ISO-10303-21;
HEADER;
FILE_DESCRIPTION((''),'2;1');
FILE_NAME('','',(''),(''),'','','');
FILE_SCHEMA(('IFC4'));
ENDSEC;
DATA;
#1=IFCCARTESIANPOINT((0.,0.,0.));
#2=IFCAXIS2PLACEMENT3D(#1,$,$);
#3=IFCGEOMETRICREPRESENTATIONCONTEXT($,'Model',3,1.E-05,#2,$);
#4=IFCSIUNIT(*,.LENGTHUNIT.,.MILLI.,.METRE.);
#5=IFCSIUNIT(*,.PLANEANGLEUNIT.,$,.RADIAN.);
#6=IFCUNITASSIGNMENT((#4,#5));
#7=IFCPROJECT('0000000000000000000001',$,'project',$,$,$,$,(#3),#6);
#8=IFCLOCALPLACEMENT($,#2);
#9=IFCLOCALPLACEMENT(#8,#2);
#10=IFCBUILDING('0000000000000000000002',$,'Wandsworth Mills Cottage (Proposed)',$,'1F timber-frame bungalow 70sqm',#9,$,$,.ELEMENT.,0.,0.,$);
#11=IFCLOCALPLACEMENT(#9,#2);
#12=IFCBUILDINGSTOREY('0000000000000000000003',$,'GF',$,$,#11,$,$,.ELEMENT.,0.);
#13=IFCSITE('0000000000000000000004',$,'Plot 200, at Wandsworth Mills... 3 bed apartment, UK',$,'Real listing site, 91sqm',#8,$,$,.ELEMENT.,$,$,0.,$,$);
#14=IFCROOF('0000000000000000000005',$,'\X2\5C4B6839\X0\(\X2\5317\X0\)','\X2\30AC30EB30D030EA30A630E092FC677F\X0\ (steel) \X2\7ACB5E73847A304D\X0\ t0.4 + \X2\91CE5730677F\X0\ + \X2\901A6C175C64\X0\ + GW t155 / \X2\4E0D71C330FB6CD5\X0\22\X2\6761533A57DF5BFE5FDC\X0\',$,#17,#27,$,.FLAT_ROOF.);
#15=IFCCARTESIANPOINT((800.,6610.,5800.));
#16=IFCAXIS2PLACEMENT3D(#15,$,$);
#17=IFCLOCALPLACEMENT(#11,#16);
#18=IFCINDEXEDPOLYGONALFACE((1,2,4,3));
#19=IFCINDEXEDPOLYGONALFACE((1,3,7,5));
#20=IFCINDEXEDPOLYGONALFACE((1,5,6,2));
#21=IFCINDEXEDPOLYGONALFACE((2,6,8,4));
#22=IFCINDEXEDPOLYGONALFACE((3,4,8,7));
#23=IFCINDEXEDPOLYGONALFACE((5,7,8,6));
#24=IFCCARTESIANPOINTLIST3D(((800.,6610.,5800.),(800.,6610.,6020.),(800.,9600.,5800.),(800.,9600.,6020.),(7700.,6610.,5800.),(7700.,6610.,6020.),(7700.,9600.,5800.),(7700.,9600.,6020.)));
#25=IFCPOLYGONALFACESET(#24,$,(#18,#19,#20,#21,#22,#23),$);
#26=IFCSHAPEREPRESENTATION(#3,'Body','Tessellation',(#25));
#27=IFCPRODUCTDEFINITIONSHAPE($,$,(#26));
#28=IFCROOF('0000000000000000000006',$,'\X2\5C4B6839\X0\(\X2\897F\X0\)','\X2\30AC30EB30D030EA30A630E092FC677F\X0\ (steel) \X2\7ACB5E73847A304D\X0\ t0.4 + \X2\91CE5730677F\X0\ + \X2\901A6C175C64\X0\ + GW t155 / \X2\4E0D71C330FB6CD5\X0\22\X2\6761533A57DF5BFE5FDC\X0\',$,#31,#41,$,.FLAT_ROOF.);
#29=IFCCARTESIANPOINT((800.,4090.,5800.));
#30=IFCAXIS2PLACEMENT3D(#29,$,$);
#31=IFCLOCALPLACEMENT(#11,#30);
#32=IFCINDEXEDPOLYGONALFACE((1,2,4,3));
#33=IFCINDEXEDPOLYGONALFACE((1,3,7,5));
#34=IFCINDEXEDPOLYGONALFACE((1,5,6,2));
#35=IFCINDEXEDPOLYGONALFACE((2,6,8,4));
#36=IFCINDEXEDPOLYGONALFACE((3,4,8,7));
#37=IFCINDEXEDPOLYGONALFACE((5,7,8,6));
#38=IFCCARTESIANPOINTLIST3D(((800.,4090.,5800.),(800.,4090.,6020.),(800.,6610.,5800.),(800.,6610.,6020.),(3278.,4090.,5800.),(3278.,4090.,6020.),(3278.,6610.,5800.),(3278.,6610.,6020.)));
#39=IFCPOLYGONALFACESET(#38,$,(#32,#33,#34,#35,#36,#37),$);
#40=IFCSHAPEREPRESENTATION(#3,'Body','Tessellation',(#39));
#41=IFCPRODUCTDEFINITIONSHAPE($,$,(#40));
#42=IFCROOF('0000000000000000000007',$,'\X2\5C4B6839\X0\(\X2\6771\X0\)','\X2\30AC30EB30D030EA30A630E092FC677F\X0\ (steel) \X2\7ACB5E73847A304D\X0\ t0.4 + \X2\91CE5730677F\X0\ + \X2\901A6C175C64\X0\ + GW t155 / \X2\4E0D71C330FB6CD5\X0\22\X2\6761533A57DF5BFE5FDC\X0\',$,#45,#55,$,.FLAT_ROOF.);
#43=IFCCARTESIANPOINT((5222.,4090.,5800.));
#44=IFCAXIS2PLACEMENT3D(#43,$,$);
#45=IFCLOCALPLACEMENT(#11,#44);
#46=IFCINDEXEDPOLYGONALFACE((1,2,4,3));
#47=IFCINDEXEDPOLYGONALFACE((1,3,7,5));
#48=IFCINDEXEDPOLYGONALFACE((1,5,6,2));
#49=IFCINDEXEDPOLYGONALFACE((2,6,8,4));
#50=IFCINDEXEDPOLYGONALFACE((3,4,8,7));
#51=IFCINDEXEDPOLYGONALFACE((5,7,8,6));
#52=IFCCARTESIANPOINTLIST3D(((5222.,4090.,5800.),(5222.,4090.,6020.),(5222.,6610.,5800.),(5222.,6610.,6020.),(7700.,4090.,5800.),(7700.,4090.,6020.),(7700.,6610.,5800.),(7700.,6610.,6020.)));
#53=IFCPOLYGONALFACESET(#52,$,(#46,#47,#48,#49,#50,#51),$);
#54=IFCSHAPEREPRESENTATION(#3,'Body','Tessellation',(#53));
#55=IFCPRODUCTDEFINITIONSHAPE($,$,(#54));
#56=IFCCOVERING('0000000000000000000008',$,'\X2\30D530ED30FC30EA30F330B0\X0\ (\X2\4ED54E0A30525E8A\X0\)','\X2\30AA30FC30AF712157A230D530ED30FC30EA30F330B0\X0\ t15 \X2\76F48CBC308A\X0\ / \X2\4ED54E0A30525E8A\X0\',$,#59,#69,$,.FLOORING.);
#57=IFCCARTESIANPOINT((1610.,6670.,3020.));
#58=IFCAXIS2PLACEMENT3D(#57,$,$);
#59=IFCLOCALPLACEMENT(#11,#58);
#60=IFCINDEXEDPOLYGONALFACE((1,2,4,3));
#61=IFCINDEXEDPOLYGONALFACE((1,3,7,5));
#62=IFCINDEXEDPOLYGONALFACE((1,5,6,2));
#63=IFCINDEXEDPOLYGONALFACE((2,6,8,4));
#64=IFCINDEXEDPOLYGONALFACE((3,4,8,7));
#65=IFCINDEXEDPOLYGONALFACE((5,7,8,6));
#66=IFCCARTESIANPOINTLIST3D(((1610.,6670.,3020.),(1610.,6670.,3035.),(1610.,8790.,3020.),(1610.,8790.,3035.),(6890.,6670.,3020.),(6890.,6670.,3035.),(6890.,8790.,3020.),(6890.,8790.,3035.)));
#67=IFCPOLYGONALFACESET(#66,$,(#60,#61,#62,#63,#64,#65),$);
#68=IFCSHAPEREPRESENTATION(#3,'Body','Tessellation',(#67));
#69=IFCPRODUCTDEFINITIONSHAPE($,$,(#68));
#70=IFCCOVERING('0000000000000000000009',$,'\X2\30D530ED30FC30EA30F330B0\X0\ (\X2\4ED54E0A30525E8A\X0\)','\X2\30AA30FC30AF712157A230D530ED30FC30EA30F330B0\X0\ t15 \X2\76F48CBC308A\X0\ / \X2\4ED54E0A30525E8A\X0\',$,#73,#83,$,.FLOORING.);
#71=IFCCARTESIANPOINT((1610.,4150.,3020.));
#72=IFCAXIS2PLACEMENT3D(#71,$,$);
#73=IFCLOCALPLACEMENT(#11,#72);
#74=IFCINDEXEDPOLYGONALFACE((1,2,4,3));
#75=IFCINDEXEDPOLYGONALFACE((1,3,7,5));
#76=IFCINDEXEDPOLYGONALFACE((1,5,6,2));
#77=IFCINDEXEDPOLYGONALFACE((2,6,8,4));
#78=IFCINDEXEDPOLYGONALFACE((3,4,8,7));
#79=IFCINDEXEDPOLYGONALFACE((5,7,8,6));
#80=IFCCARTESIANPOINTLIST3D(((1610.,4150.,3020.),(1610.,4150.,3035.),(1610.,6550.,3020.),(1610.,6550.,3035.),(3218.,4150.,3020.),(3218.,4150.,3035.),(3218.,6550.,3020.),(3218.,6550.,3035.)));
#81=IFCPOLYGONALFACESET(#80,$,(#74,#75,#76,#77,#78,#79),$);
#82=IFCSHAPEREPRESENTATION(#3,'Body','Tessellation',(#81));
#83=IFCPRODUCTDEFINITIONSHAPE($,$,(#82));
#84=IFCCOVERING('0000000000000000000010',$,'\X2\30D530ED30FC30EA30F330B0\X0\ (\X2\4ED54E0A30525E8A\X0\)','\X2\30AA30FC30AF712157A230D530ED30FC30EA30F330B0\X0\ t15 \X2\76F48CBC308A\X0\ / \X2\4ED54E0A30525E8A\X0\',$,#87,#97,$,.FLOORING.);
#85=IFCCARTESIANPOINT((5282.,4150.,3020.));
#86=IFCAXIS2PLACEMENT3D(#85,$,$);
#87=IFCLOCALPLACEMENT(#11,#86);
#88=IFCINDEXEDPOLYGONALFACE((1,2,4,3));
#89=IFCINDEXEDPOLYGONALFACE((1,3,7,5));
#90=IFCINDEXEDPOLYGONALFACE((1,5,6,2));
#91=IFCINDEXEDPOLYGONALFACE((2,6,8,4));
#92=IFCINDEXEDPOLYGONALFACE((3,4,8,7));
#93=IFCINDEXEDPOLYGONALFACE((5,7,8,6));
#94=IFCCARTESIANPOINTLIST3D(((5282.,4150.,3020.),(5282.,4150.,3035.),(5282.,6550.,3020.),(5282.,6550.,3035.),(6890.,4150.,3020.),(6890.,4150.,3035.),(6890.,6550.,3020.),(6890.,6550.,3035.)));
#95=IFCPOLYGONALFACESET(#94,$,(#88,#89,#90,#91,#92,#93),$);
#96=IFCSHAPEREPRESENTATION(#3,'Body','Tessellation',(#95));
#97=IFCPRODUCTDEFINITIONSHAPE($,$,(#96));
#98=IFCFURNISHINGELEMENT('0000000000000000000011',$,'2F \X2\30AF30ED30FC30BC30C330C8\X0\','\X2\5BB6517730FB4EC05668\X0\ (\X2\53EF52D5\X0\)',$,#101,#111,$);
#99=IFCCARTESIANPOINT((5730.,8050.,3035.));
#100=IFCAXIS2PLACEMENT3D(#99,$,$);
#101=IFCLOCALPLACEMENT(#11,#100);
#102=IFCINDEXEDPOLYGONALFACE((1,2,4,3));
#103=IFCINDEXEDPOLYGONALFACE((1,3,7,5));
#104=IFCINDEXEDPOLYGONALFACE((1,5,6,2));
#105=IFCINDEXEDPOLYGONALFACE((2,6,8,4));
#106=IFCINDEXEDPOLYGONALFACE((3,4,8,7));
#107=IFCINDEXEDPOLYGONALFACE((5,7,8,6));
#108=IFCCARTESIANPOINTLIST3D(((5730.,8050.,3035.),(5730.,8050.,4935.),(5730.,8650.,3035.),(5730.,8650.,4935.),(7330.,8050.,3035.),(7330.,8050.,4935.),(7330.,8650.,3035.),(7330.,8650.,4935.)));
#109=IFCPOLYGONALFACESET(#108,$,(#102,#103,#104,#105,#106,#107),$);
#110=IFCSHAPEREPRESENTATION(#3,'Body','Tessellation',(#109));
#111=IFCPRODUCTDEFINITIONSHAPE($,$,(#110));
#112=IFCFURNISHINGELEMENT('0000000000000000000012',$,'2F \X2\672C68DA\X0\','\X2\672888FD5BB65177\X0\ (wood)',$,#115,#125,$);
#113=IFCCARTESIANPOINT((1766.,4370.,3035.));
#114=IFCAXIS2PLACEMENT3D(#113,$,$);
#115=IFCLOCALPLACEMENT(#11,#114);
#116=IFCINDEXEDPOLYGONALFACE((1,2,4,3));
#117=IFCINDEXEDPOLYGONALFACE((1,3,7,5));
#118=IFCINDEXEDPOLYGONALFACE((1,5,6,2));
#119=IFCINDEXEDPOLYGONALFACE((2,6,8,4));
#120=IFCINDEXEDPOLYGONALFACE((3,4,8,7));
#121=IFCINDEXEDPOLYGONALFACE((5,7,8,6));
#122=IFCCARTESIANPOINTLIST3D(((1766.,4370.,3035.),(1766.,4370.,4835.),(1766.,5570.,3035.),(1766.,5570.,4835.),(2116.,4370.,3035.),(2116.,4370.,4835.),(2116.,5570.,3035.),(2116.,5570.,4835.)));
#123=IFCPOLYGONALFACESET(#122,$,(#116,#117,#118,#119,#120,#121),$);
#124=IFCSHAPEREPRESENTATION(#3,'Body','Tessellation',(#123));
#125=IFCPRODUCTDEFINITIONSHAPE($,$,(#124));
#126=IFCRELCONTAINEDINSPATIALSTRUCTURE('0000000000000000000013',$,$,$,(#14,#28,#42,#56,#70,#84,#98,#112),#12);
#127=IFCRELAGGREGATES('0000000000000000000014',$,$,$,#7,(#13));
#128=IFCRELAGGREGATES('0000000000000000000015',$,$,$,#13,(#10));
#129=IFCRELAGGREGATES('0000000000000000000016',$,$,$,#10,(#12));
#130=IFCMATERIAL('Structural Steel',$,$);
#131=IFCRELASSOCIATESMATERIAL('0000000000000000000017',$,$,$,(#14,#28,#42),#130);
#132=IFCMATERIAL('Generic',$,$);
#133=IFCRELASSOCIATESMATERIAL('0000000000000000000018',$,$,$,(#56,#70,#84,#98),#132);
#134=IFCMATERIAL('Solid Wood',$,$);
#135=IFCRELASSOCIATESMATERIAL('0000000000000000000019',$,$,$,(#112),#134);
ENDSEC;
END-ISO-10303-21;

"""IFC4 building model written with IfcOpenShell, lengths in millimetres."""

from ifc_helpers import new_model, si_unit, frame, frame_2d, origin, place, context, project, spatial, rectangle, extrude, material, element, save


model = new_model("IFC4")

# Units and contexts
model_context = context("Model", 3, precision=1e-05, world=origin())
ifc_project = project(units=[si_unit("LENGTHUNIT", "METRE", prefix="MILLI"), si_unit("PLANEANGLEUNIT", "RADIAN")], contexts=[model_context])

# Site, building, storey
site_placement = place(None, origin())
site = spatial("IfcSite", under=ifc_project, at=site_placement, Name="Plot 200, at Wandsworth Mills... 3 bed apartment, UK", ObjectType="Real listing site, 91sqm", CompositionType="ELEMENT", RefElevation=0.0)
building_placement = place(site_placement, origin())
building = spatial("IfcBuilding", under=site, at=building_placement, Name="Wandsworth Mills Cottage (Proposed)", ObjectType="1F timber-frame bungalow 70sqm", CompositionType="ELEMENT", ElevationOfRefHeight=0.0, ElevationOfTerrain=0.0)
storey_placement = place(building_placement, origin())
storey = spatial("IfcBuildingStorey", under=building, at=storey_placement, Name="GF", CompositionType="ELEMENT", Elevation=0.0)

# Shared definitions
ifc_material_1 = material(Name="Solid Wood")

# Roofs
ifc_material_2 = material(Name="Structural Steel")
for number, where, name in (
    (1, (800.0, 6610.0, 5800.0), "屋根(北)"),
):
    element("IfcRoof", number, at=place(storey_placement, frame(where)), inside=storey, material=ifc_material_2, Name=name, Description="ガルバリウム鋼板 (steel) 立平葺き t0.4 + 野地板 + 通気層 + GW t155 / 不燃・法22条区域対応", PredefinedType="FLAT_ROOF", context=model_context, shape_type="SweptSolid", body=[
        extrude(rectangle(XDim=6900.0, YDim=2990.0, at=frame_2d((3450.0, 1495.0))), frame((800.0, 6610.0, 5800.0)), (0.0, 0.0, 1.0), 220.0),
    ])
roof_1_placement = place(storey_placement, frame((800.0, 4090.0, 5800.0)))
element("IfcRoof", 2, at=roof_1_placement, inside=storey, material=ifc_material_2, Name="屋根(西)", Description="ガルバリウム鋼板 (steel) 立平葺き t0.4 + 野地板 + 通気層 + GW t155 / 不燃・法22条区域対応", PredefinedType="FLAT_ROOF", context=model_context, shape_type="SweptSolid", body=[
    extrude(rectangle(XDim=2478.0, YDim=2520.0, at=frame_2d((1239.0, 1260.0))), frame((800.0, 4090.0, 5800.0)), (0.0, 0.0, 1.0), 220.0),
])
roof_2_placement = place(storey_placement, frame((5222.0, 4090.0, 5800.0)))
element("IfcRoof", 3, at=roof_2_placement, inside=storey, material=ifc_material_2, Name="屋根(東)", Description="ガルバリウム鋼板 (steel) 立平葺き t0.4 + 野地板 + 通気層 + GW t155 / 不燃・法22条区域対応", PredefinedType="FLAT_ROOF", context=model_context, shape_type="SweptSolid", body=[
    extrude(rectangle(XDim=2478.0, YDim=2520.0, at=frame_2d((1239.0, 1260.0))), frame((5222.0, 4090.0, 5800.0)), (0.0, 0.0, 1.0), 220.0),
])

# Coverings
ifc_material_3 = material(Name="Generic")
covering_1_placement = place(storey_placement, frame((1610.0, 6670.0, 3020.0)))
element("IfcCovering", 4, at=covering_1_placement, inside=storey, material=ifc_material_3, Name="フローリング (仕上げ床)", Description="オーク無垢フローリング t15 直貼り / 仕上げ床", PredefinedType="FLOORING", context=model_context, shape_type="SweptSolid", body=[
    extrude(rectangle(XDim=5280.0, YDim=2120.0, at=frame_2d((2640.0, 1060.0))), frame((1610.0, 6670.0, 3020.0)), (0.0, 0.0, 1.0), 15.0),
])
covering_2_placement = place(storey_placement, frame((1610.0, 4150.0, 3020.0)))
element("IfcCovering", 5, at=covering_2_placement, inside=storey, material=ifc_material_3, Name="フローリング (仕上げ床)", Description="オーク無垢フローリング t15 直貼り / 仕上げ床", PredefinedType="FLOORING", context=model_context, shape_type="SweptSolid", body=[
    extrude(rectangle(XDim=1608.0, YDim=2400.0, at=frame_2d((804.0, 1200.0))), frame((1610.0, 4150.0, 3020.0)), (0.0, 0.0, 1.0), 15.0),
])
covering_3_placement = place(storey_placement, frame((5282.0, 4150.0, 3020.0)))
element("IfcCovering", 6, at=covering_3_placement, inside=storey, material=ifc_material_3, Name="フローリング (仕上げ床)", Description="オーク無垢フローリング t15 直貼り / 仕上げ床", PredefinedType="FLOORING", context=model_context, shape_type="SweptSolid", body=[
    extrude(rectangle(XDim=1608.0, YDim=2400.0, at=frame_2d((804.0, 1200.0))), frame((5282.0, 4150.0, 3020.0)), (0.0, 0.0, 1.0), 15.0),
])

# Furnishing elements
furnishing_1_placement = place(storey_placement, frame((5730.0, 8050.0, 3035.0)))
element("IfcFurnishingElement", 7, at=furnishing_1_placement, inside=storey, material=ifc_material_3, Name="2F クローゼット", Description="家具・什器 (可動)", context=model_context, shape_type="SweptSolid", body=[
    extrude(rectangle(XDim=1600.0, YDim=600.0, at=frame_2d((800.0, 300.0))), frame((5730.0, 8050.0, 3035.0)), (0.0, 0.0, 1.0), 1900.0),
])
furnishing_2_placement = place(storey_placement, frame((1766.0, 4370.0, 3035.0)))
element("IfcFurnishingElement", 8, at=furnishing_2_placement, inside=storey, material=ifc_material_1, Name="2F 本棚", Description="木製家具 (wood)", context=model_context, shape_type="SweptSolid", body=[
    extrude(rectangle(XDim=350.0, YDim=1200.0, at=frame_2d((175.0, 600.0))), frame((1766.0, 4370.0, 3035.0)), (0.0, 0.0, 1.0), 1800.0),
])

save(model, "model.ifc")
